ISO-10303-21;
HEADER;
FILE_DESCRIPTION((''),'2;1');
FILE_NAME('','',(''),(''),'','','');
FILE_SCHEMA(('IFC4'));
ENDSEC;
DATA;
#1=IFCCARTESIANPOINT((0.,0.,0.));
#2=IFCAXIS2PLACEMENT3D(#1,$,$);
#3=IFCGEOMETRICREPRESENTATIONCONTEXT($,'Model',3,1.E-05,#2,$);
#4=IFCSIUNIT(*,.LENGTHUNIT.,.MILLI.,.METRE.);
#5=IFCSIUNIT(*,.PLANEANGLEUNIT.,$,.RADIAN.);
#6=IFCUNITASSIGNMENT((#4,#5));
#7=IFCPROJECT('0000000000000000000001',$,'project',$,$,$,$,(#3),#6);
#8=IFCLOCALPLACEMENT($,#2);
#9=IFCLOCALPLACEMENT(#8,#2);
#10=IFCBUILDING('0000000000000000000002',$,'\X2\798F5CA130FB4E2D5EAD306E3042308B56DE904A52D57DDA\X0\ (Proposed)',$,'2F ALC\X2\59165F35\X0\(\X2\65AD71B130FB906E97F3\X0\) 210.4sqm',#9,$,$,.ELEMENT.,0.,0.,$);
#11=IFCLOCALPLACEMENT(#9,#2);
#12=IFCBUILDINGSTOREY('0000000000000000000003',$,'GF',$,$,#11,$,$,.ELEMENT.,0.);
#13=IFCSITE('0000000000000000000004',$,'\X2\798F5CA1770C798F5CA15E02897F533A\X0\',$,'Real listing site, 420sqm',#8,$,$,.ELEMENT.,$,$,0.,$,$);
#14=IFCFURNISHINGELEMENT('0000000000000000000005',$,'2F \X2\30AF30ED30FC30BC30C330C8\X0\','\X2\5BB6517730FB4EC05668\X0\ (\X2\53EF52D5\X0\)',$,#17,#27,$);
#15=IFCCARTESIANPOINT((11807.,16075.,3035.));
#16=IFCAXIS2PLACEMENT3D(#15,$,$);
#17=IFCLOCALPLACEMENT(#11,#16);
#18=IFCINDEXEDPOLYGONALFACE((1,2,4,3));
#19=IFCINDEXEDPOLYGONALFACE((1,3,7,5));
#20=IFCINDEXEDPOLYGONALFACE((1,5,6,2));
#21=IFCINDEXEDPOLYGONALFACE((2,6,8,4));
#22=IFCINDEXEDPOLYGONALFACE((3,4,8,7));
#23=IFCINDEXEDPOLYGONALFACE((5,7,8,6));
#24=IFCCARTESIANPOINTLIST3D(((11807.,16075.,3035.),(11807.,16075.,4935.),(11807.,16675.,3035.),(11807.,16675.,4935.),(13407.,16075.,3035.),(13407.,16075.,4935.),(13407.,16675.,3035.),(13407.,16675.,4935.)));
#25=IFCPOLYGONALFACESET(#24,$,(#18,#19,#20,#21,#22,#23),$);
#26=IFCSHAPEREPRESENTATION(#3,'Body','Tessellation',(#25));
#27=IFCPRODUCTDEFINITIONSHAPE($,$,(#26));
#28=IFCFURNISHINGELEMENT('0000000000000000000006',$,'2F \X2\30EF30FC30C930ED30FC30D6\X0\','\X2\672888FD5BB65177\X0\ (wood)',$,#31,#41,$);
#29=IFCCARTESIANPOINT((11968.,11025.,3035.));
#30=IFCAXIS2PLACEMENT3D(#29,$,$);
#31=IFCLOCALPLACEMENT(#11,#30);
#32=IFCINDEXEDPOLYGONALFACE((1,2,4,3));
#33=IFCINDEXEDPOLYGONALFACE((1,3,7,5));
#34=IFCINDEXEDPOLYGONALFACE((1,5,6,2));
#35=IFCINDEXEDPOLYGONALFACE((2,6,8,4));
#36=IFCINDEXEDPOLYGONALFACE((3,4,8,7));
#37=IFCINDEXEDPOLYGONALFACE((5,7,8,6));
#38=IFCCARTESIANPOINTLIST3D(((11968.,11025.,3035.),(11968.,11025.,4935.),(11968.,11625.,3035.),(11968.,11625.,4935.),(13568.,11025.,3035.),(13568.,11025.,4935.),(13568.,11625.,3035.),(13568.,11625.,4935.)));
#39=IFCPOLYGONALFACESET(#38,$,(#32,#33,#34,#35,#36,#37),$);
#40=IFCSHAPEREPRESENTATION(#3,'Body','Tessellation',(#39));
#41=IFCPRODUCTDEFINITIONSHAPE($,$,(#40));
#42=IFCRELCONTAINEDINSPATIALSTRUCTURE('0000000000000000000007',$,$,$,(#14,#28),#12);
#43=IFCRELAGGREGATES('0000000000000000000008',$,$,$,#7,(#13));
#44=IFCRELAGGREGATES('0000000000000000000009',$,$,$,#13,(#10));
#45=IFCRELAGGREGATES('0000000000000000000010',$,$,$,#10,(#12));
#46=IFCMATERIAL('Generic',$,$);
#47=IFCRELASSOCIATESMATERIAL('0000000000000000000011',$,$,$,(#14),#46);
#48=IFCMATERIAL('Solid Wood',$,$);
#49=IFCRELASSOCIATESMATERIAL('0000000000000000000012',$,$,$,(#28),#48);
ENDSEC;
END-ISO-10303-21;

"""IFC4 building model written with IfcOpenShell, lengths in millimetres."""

from ifc_helpers import new_model, si_unit, frame, frame_2d, origin, place, context, project, spatial, rectangle, extrude, material, element, save


model = new_model("IFC4")

# Units and contexts
model_context = context("Model", 3, precision=1e-05, world=origin())
ifc_project = project(units=[si_unit("LENGTHUNIT", "METRE", prefix="MILLI"), si_unit("PLANEANGLEUNIT", "RADIAN")], contexts=[model_context])

# Site, building, storey
site_placement = place(None, origin())
site = spatial("IfcSite", under=ifc_project, at=site_placement, Name="福岡県福岡市西区", ObjectType="Real listing site, 420sqm", CompositionType="ELEMENT", RefElevation=0.0)
building_placement = place(site_placement, origin())
building = spatial("IfcBuilding", under=site, at=building_placement, Name="福岡・中庭のある回遊動線 (Proposed)", ObjectType="2F ALC外張(断熱・遮音) 210.4sqm", CompositionType="ELEMENT", ElevationOfRefHeight=0.0, ElevationOfTerrain=0.0)
storey_placement = place(building_placement, origin())
storey = spatial("IfcBuildingStorey", under=building, at=storey_placement, Name="GF", CompositionType="ELEMENT", Elevation=0.0)

# Shared definitions
ifc_material_1 = material(Name="Solid Wood")

# Shared definitions
ifc_material_2 = material(Name="Generic")

# Furnishing elements
furnishing_1_placement = place(storey_placement, frame((11807.0, 16075.0, 3035.0)))
element("IfcFurnishingElement", 1, at=furnishing_1_placement, inside=storey, material=ifc_material_2, Name="2F クローゼット", Description="家具・什器 (可動)", context=model_context, shape_type="SweptSolid", body=[
    extrude(rectangle(XDim=1600.0, YDim=600.0, at=frame_2d((800.0, 300.0))), frame((11807.0, 16075.0, 3035.0)), (0.0, 0.0, 1.0), 1900.0),
])
furnishing_2_placement = place(storey_placement, frame((11968.0, 11025.0, 3035.0)))
element("IfcFurnishingElement", 2, at=furnishing_2_placement, inside=storey, material=ifc_material_1, Name="2F ワードローブ", Description="木製家具 (wood)", context=model_context, shape_type="SweptSolid", body=[
    extrude(rectangle(XDim=1600.0, YDim=600.0, at=frame_2d((800.0, 300.0))), frame((11968.0, 11025.0, 3035.0)), (0.0, 0.0, 1.0), 1900.0),
])

save(model, "model.ifc")
